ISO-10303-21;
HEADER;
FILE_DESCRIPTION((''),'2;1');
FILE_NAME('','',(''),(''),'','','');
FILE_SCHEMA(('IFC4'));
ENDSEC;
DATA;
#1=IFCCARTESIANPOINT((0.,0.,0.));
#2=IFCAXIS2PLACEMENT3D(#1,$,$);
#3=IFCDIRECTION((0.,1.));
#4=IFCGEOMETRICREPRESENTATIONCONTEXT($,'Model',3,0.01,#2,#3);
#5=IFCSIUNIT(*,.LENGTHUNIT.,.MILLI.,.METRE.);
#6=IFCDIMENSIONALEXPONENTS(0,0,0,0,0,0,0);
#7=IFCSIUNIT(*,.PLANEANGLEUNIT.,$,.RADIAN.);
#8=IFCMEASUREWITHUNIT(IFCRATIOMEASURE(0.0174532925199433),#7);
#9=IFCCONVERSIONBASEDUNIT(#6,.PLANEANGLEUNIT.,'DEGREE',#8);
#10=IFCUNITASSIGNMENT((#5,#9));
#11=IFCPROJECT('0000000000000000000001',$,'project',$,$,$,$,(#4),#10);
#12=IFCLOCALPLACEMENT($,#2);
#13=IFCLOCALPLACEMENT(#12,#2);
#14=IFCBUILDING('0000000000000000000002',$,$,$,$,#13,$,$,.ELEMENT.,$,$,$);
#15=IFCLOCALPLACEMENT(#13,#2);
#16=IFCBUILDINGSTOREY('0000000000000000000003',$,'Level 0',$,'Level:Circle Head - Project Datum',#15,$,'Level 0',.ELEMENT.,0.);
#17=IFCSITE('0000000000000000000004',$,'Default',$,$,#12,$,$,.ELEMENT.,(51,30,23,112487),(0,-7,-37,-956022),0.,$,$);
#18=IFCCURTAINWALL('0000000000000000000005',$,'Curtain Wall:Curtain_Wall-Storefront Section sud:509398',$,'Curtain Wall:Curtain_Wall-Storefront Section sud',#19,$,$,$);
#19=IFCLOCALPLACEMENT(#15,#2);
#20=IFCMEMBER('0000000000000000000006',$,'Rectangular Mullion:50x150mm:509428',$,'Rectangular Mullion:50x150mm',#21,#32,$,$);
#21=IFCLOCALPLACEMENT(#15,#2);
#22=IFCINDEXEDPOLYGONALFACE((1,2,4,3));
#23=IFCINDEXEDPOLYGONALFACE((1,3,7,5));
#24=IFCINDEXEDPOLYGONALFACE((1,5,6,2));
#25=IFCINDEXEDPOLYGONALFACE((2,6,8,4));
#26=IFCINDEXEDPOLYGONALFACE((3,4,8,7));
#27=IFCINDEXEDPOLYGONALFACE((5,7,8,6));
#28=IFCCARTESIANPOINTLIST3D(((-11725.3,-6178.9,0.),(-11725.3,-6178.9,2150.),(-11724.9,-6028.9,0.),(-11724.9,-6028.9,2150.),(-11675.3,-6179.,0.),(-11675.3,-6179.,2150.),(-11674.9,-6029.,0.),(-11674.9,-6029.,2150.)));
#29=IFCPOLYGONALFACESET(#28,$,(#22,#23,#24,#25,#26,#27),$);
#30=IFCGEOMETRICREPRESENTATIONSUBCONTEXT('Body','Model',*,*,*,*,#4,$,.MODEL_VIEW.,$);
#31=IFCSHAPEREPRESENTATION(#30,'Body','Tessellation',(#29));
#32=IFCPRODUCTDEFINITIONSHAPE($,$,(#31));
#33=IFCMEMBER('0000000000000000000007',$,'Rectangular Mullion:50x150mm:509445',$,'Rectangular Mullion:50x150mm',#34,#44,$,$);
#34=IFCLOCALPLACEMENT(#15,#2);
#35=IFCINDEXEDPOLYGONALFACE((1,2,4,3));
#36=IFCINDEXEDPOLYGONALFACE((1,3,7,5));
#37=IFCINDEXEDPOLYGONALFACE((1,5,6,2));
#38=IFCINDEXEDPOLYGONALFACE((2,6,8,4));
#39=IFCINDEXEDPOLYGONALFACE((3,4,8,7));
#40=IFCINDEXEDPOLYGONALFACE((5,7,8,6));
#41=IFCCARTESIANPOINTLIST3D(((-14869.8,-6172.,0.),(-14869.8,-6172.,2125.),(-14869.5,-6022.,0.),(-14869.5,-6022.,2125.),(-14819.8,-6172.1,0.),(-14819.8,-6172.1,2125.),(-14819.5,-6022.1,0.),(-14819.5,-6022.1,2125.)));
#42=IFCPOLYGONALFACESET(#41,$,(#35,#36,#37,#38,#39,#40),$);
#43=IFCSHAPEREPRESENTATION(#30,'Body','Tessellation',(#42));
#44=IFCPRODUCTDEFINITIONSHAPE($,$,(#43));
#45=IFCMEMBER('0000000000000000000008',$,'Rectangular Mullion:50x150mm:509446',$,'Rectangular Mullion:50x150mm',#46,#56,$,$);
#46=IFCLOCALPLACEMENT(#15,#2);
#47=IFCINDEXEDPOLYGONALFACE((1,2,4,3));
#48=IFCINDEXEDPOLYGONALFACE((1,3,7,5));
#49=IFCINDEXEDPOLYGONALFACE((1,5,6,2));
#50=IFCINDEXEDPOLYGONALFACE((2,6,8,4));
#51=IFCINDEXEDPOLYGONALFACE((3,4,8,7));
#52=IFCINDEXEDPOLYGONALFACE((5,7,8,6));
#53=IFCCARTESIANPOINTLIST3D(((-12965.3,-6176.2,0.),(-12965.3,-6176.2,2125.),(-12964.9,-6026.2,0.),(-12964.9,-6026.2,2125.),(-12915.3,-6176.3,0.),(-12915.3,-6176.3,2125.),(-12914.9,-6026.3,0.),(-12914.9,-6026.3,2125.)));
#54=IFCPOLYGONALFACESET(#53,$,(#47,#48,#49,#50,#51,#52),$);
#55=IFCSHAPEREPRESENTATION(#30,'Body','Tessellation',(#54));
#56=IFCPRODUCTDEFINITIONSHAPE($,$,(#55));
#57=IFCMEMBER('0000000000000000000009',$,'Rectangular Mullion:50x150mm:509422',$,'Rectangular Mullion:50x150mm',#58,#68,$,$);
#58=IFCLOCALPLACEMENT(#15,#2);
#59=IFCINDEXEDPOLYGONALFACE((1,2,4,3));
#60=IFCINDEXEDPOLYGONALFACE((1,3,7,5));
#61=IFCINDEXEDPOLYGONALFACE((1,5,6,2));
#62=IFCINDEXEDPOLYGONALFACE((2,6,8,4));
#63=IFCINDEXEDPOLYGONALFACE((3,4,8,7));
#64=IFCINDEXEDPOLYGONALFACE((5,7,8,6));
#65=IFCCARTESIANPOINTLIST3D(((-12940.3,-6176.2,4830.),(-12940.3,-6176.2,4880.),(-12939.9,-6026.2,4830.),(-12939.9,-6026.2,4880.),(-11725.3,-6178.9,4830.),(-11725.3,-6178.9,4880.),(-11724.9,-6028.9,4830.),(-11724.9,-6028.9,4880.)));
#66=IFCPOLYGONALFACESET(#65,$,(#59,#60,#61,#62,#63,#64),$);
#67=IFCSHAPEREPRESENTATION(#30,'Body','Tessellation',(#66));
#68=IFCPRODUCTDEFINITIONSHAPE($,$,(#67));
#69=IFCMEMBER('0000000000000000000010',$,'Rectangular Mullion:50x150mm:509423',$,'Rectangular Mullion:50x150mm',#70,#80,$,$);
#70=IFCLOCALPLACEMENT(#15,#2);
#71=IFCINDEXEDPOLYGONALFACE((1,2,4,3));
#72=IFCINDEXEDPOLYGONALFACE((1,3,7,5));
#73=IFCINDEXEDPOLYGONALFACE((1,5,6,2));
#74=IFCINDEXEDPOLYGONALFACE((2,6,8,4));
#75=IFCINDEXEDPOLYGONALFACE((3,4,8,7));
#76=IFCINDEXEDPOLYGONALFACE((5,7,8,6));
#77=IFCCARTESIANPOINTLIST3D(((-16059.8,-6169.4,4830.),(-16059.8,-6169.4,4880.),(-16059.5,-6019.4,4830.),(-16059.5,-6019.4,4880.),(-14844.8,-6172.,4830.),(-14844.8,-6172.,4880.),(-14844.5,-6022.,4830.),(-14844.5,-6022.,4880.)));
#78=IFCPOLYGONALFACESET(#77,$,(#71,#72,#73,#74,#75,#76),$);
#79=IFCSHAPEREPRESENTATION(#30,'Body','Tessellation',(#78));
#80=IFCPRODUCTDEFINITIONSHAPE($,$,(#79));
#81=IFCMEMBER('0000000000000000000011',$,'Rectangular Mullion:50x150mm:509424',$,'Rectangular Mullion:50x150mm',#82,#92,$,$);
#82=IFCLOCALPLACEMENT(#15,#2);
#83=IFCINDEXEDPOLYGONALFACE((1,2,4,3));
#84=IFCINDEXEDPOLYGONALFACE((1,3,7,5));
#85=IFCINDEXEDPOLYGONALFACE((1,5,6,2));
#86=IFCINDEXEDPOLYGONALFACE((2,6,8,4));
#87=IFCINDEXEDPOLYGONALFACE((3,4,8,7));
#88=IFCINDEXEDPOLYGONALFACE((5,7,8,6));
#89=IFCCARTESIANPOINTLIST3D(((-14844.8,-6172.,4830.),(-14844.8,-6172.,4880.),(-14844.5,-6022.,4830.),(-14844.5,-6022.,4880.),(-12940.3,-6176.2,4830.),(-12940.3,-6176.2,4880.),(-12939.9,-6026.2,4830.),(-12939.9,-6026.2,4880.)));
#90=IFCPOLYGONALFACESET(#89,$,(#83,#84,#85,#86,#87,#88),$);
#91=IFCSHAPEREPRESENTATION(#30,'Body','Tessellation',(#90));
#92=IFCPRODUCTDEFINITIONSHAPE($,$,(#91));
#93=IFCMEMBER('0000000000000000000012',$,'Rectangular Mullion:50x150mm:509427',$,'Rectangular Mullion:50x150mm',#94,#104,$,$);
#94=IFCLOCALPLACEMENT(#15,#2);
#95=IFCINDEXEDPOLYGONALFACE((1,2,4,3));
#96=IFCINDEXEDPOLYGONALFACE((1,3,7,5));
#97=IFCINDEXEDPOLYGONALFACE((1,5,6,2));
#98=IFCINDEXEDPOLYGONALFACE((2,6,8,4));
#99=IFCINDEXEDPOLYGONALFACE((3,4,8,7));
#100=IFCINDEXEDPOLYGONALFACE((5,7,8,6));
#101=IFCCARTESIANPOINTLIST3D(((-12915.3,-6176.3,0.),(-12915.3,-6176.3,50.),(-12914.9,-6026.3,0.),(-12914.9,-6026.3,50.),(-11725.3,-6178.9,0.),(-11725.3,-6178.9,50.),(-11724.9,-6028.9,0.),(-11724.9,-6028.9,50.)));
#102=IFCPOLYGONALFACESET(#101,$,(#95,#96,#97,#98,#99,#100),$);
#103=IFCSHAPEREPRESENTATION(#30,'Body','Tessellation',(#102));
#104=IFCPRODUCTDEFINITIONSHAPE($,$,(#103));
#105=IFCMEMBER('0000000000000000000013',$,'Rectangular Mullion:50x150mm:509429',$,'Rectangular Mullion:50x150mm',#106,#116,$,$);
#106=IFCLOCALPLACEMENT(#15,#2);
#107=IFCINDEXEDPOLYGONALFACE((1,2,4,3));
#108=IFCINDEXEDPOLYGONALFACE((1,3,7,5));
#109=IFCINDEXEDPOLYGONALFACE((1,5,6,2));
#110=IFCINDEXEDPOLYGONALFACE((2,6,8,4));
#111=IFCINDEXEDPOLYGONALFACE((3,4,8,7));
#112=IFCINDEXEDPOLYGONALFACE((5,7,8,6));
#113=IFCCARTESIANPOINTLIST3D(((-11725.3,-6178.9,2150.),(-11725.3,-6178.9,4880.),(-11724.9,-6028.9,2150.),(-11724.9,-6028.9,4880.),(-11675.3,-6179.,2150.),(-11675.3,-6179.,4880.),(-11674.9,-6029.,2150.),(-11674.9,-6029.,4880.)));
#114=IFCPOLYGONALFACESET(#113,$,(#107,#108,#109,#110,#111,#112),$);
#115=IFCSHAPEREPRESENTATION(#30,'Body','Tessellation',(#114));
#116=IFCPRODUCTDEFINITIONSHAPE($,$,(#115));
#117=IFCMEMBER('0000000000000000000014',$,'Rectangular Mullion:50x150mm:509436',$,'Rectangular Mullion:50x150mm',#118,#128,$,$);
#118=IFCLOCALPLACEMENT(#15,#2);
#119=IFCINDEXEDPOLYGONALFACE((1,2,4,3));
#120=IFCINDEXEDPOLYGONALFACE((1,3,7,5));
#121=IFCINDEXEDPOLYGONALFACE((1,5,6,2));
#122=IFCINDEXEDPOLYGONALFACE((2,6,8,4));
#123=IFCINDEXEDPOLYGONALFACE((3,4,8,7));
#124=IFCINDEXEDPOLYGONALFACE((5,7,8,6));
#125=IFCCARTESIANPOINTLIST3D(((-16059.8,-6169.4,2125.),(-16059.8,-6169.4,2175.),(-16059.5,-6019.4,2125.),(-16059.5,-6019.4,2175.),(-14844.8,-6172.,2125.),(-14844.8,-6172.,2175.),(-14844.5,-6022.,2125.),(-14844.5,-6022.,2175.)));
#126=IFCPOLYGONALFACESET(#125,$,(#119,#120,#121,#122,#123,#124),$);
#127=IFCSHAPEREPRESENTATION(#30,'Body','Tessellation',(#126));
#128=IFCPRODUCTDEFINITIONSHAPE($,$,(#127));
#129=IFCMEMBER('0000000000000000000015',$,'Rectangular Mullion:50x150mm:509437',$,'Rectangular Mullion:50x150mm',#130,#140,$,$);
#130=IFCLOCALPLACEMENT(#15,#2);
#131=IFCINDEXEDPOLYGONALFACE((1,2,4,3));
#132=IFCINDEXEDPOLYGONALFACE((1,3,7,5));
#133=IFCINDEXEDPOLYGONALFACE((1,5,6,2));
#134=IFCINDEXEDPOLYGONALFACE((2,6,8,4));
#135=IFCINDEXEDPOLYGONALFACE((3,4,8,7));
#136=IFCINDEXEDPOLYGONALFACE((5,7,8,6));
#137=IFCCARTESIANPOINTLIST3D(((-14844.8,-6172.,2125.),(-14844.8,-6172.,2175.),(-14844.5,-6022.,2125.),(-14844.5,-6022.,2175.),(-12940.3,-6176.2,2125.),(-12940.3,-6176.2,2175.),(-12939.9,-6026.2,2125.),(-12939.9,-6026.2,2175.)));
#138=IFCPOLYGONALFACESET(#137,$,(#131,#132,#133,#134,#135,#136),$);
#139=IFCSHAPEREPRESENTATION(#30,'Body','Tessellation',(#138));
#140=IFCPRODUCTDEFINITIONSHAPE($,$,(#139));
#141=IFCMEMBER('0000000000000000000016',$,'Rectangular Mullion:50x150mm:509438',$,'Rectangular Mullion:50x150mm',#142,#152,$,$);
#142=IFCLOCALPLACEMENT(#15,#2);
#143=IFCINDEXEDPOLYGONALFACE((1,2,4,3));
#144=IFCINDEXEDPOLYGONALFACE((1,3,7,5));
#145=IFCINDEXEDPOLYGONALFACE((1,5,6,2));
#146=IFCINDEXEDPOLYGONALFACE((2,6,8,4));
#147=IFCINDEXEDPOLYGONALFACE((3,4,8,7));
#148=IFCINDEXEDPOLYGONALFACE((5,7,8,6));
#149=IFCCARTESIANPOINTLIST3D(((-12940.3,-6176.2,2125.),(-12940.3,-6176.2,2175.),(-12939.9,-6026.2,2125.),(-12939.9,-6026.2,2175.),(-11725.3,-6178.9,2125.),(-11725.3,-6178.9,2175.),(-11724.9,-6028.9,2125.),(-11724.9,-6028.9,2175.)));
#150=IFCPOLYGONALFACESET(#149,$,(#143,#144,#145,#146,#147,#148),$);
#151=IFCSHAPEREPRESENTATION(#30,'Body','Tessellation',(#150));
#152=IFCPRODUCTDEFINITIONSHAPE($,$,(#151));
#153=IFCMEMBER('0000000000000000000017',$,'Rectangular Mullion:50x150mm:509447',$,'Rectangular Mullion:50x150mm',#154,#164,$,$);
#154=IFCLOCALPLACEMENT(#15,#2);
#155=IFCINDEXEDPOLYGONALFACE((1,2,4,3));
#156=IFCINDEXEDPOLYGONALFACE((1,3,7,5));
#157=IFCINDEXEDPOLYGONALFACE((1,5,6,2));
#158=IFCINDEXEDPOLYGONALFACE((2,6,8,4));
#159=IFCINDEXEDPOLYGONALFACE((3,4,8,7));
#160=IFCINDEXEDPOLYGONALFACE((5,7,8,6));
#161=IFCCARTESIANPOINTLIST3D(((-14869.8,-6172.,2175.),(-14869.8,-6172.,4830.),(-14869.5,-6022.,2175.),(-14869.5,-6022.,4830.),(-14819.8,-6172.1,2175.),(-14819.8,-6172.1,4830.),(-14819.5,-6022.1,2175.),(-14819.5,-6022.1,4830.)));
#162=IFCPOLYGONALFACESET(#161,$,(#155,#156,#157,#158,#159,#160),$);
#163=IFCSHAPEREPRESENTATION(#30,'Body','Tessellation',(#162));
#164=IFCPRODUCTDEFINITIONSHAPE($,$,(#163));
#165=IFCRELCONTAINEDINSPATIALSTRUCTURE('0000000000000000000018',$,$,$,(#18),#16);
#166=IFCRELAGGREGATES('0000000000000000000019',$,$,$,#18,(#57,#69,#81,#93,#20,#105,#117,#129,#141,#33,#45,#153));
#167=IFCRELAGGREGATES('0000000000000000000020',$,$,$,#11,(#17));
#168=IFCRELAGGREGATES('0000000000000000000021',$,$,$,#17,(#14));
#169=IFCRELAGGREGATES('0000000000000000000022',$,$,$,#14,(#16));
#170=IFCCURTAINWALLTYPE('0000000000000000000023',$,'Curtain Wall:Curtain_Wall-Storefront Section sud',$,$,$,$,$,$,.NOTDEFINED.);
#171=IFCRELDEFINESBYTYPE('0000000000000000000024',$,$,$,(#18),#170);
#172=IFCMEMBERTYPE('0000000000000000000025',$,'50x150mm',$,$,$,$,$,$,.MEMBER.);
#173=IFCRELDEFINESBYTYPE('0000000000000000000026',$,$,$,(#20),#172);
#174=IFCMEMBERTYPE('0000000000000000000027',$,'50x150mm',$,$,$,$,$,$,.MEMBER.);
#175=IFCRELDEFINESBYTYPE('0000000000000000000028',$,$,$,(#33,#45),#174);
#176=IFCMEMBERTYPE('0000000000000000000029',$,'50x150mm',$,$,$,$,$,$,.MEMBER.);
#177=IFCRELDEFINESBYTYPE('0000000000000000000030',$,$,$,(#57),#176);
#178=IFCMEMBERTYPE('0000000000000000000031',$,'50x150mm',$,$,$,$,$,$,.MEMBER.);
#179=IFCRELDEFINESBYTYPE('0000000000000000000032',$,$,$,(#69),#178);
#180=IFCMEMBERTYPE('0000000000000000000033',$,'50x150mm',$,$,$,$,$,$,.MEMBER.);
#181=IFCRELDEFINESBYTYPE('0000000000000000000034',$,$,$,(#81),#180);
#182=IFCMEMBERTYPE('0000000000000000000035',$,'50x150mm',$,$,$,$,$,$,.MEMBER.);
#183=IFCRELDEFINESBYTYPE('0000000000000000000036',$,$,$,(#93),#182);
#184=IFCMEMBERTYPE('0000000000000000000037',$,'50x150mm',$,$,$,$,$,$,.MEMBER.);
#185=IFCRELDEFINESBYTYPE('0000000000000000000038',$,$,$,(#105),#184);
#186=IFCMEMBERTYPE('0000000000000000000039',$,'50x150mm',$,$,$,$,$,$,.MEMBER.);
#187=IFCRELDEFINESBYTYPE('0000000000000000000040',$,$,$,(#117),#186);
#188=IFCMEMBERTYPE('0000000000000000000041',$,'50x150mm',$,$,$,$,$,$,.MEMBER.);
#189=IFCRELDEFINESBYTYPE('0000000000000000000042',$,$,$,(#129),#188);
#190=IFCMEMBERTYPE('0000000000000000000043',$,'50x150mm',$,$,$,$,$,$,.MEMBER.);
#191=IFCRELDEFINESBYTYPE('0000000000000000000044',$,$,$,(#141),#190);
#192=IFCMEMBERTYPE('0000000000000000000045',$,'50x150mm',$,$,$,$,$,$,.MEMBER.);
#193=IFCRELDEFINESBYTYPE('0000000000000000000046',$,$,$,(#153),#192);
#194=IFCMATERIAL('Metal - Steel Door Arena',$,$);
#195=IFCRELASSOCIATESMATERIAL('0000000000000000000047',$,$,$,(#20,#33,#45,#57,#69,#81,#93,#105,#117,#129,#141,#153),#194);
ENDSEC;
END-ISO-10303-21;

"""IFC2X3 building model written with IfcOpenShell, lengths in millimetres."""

from ifc_helpers import new_model, entity, si_unit, converted_unit, direction, frame, origin, origin_2d_with_axis, place, context, subcontext, project, spatial, rectangle, extrude, source, transform, mapped, material, type_object, type_shapes, element, aggregate, save


model = new_model("IFC2X3")

# Units and contexts
model_context = context("Model", 3, precision=0.01, world=origin(), true_north=direction((0.0, 1.0)))
body_context = subcontext(model_context, "Body", "Model", "MODEL_VIEW")
ifc_project = project(units=[si_unit("LENGTHUNIT", "METRE", prefix="MILLI"), converted_unit("PLANEANGLEUNIT", "DEGREE", entity("IfcRatioMeasure", 0.0174532925199433), si_unit("PLANEANGLEUNIT", "RADIAN"), dimensions=[0, 0, 0, 0, 0, 0, 0])], contexts=[model_context])

# Site, building, storey
site_placement = place(None, origin())
site = spatial("IfcSite", under=ifc_project, at=site_placement, Name="Default", CompositionType="ELEMENT", RefLatitude=(51, 30, 23, 112487), RefLongitude=(0, -7, -37, -956022), RefElevation=0.0)
building_placement = place(site_placement, origin())
building = spatial("IfcBuilding", under=site, at=building_placement, CompositionType="ELEMENT")
storey_placement = place(building_placement, origin())
storey = spatial("IfcBuildingStorey", under=building, at=storey_placement, Name="Level 0", ObjectType="Level:Circle Head - Project Datum", LongName="Level 0", CompositionType="ELEMENT", Elevation=0.0)

# Curtain wall, members
curtain_wall_type = type_object("IfcCurtainWallType", Name="Curtain Wall:Curtain_Wall-Storefront Section sud", PredefinedType="NOTDEFINED")
curtain_wall_placement = place(storey_placement, origin())
curtain_wall = element("IfcCurtainWall", 1, at=curtain_wall_placement, inside=storey, type_object=curtain_wall_type, Name="Curtain Wall:Curtain_Wall-Storefront Section sud:509398", ObjectType="Curtain Wall:Curtain_Wall-Storefront Section sud")
ifc_material_1 = material(Name="Metal - Steel Door Arena")
member_type_1 = type_object("IfcMemberType", Name="50x150mm", PredefinedType="MEMBER")
shared_shape_1 = source(origin(), body_context, "Body", "SweptSolid", [
    extrude(rectangle(XDim=150.0, YDim=50.0, at=origin_2d_with_axis()), frame((-25.0, 0.0, -2150.0), z_axis=(0.0, 0.0, 1.0), x_axis=(0.0, -1.0, 0.0)), (0.0, 0.0, 1.0), 2150.0),
])
type_shapes(member_type_1, [shared_shape_1])
member_1_placement = place(storey_placement, frame((-11675.1, -6104.0, 0.0), z_axis=(0.0, 0.0, -1.0), x_axis=(0.999998, -0.002199, 0.0)))
member_1 = element("IfcMember", 2, at=member_1_placement, type_object=member_type_1, material=ifc_material_1, Name="Rectangular Mullion:50x150mm:509428", ObjectType="Rectangular Mullion:50x150mm", context=body_context, shape_type="MappedRepresentation", body=[
    mapped(shared_shape_1, transform((0.0, 0.0, 0.0), scale=1.0)),
])
member_type_2 = type_object("IfcMemberType", Name="50x150mm", PredefinedType="MEMBER")
shared_shape_2 = source(origin(), body_context, "Body", "SweptSolid", [
    extrude(rectangle(XDim=150.0, YDim=50.0, at=origin_2d_with_axis()), frame((0.0, 0.0, -2125.0), z_axis=(0.0, 0.0, 1.0), x_axis=(0.0, -1.0, 0.0)), (0.0, 0.0, 1.0), 2125.0),
])
type_shapes(member_type_2, [shared_shape_2])
member_2_placement = place(storey_placement, frame((-14844.6, -6097.0, 0.0), z_axis=(0.0, 0.0, -1.0), x_axis=(0.999998, -0.002199, 0.0)))
member_2 = element("IfcMember", 3, at=member_2_placement, type_object=member_type_2, material=ifc_material_1, Name="Rectangular Mullion:50x150mm:509445", ObjectType="Rectangular Mullion:50x150mm", context=body_context, shape_type="MappedRepresentation", body=[
    mapped(shared_shape_2, transform((0.0, 0.0, 0.0), scale=1.0)),
])
member_3_placement = place(storey_placement, frame((-12940.1, -6101.2, 0.0), z_axis=(0.0, 0.0, -1.0), x_axis=(0.999998, -0.002199, 0.0)))
member_3 = element("IfcMember", 4, at=member_3_placement, type_object=member_type_2, material=ifc_material_1, Name="Rectangular Mullion:50x150mm:509446", ObjectType="Rectangular Mullion:50x150mm", context=body_context, shape_type="MappedRepresentation", body=[
    mapped(shared_shape_2, transform((0.0, 0.0, 0.0), scale=1.0)),
])
member_type_3 = type_object("IfcMemberType", Name="50x150mm", PredefinedType="MEMBER")
shared_shape_3 = source(origin(), body_context, "Body", "SweptSolid", [
    extrude(rectangle(XDim=150.0, YDim=50.0, at=origin_2d_with_axis()), frame((-25.0, 0.0, -1215.0), z_axis=(0.0, 0.0, 1.0), x_axis=(0.0, -1.0, 0.0)), (0.0, 0.0, 1.0), 1215.0),
])
type_shapes(member_type_3, [shared_shape_3])
member_4_placement = place(storey_placement, frame((-11725.1, -6103.9, 4880.0), z_axis=(0.999998, -0.002199, 0.0), x_axis=(0.0, 0.0, 1.0)))
member_4 = element("IfcMember", 5, at=member_4_placement, type_object=member_type_3, material=ifc_material_1, Name="Rectangular Mullion:50x150mm:509422", ObjectType="Rectangular Mullion:50x150mm", context=body_context, shape_type="MappedRepresentation", body=[
    mapped(shared_shape_3, transform((0.0, 0.0, 0.0), scale=1.0)),
])
member_type_4 = type_object("IfcMemberType", Name="50x150mm", PredefinedType="MEMBER")
shared_shape_4 = source(origin(), body_context, "Body", "SweptSolid", [
    extrude(rectangle(XDim=150.0, YDim=50.0, at=origin_2d_with_axis()), frame((-25.0, 0.0, -1215.0), z_axis=(0.0, 0.0, 1.0), x_axis=(0.0, -1.0, 0.0)), (0.0, 0.0, 1.0), 1215.0),
])
type_shapes(member_type_4, [shared_shape_4])
member_5_placement = place(storey_placement, frame((-14844.6, -6097.0, 4880.0), z_axis=(0.999998, -0.002199, 0.0), x_axis=(0.0, 0.0, 1.0)))
member_5 = element("IfcMember", 6, at=member_5_placement, type_object=member_type_4, material=ifc_material_1, Name="Rectangular Mullion:50x150mm:509423", ObjectType="Rectangular Mullion:50x150mm", context=body_context, shape_type="MappedRepresentation", body=[
    mapped(shared_shape_4, transform((0.0, 0.0, 0.0), scale=1.0)),
])
member_type_5 = type_object("IfcMemberType", Name="50x150mm", PredefinedType="MEMBER")
shared_shape_5 = source(origin(), body_context, "Body", "SweptSolid", [
    extrude(rectangle(XDim=150.0, YDim=50.0, at=origin_2d_with_axis()), frame((-25.0, 0.0, -1904.5), z_axis=(0.0, 0.0, 1.0), x_axis=(0.0, -1.0, 0.0)), (0.0, 0.0, 1.0), 1904.5),
])
type_shapes(member_type_5, [shared_shape_5])
member_6_placement = place(storey_placement, frame((-12940.1, -6101.2, 4880.0), z_axis=(0.999998, -0.002199, 0.0), x_axis=(0.0, 0.0, 1.0)))
member_6 = element("IfcMember", 7, at=member_6_placement, type_object=member_type_5, material=ifc_material_1, Name="Rectangular Mullion:50x150mm:509424", ObjectType="Rectangular Mullion:50x150mm", context=body_context, shape_type="MappedRepresentation", body=[
    mapped(shared_shape_5, transform((0.0, 0.0, 0.0), scale=1.0)),
])
member_type_6 = type_object("IfcMemberType", Name="50x150mm", PredefinedType="MEMBER")
shared_shape_6 = source(origin(), body_context, "Body", "SweptSolid", [
    extrude(rectangle(XDim=150.0, YDim=50.0, at=origin_2d_with_axis()), frame((-25.0, 0.0, -1190.0), z_axis=(0.0, 0.0, 1.0), x_axis=(0.0, -1.0, 0.0)), (0.0, 0.0, 1.0), 1190.0),
])
type_shapes(member_type_6, [shared_shape_6])
member_7_placement = place(storey_placement, frame((-12915.1, -6101.3, 0.0), z_axis=(-0.999998, 0.002199, 0.0), x_axis=(0.0, 0.0, -1.0)))
member_7 = element("IfcMember", 8, at=member_7_placement, type_object=member_type_6, material=ifc_material_1, Name="Rectangular Mullion:50x150mm:509427", ObjectType="Rectangular Mullion:50x150mm", context=body_context, shape_type="MappedRepresentation", body=[
    mapped(shared_shape_6, transform((0.0, 0.0, 0.0), scale=1.0)),
])
member_type_7 = type_object("IfcMemberType", Name="50x150mm", PredefinedType="MEMBER")
shared_shape_7 = source(origin(), body_context, "Body", "SweptSolid", [
    extrude(rectangle(XDim=150.0, YDim=50.0, at=origin_2d_with_axis()), frame((-25.0, 0.0, -2730.0), z_axis=(0.0, 0.0, 1.0), x_axis=(0.0, -1.0, 0.0)), (0.0, 0.0, 1.0), 2730.0),
])
type_shapes(member_type_7, [shared_shape_7])
member_8_placement = place(storey_placement, frame((-11675.1, -6104.0, 2150.0), z_axis=(0.0, 0.0, -1.0), x_axis=(0.999998, -0.002199, 0.0)))
member_8 = element("IfcMember", 9, at=member_8_placement, type_object=member_type_7, material=ifc_material_1, Name="Rectangular Mullion:50x150mm:509429", ObjectType="Rectangular Mullion:50x150mm", context=body_context, shape_type="MappedRepresentation", body=[
    mapped(shared_shape_7, transform((0.0, 0.0, 0.0), scale=1.0)),
])
member_type_8 = type_object("IfcMemberType", Name="50x150mm", PredefinedType="MEMBER")
shared_shape_8 = source(origin(), body_context, "Body", "SweptSolid", [
    extrude(rectangle(XDim=150.0, YDim=50.0, at=origin_2d_with_axis()), frame((0.0, 0.0, -1215.0), z_axis=(0.0, 0.0, 1.0), x_axis=(0.0, -1.0, 0.0)), (0.0, 0.0, 1.0), 1215.0),
])
type_shapes(member_type_8, [shared_shape_8])
member_9_placement = place(storey_placement, frame((-14844.6, -6097.0, 2150.0), z_axis=(0.999998, -0.002199, 0.0), x_axis=(0.0, 0.0, 1.0)))
member_9 = element("IfcMember", 10, at=member_9_placement, type_object=member_type_8, material=ifc_material_1, Name="Rectangular Mullion:50x150mm:509436", ObjectType="Rectangular Mullion:50x150mm", context=body_context, shape_type="MappedRepresentation", body=[
    mapped(shared_shape_8, transform((0.0, 0.0, 0.0), scale=1.0)),
])
member_type_9 = type_object("IfcMemberType", Name="50x150mm", PredefinedType="MEMBER")
shared_shape_9 = source(origin(), body_context, "Body", "SweptSolid", [
    extrude(rectangle(XDim=150.0, YDim=50.0, at=origin_2d_with_axis()), frame((0.0, 0.0, -1904.5), z_axis=(0.0, 0.0, 1.0), x_axis=(0.0, -1.0, 0.0)), (0.0, 0.0, 1.0), 1904.5),
])
type_shapes(member_type_9, [shared_shape_9])
member_10_placement = place(storey_placement, frame((-12940.1, -6101.2, 2150.0), z_axis=(0.999998, -0.002199, 0.0), x_axis=(0.0, 0.0, 1.0)))
member_10 = element("IfcMember", 11, at=member_10_placement, type_object=member_type_9, material=ifc_material_1, Name="Rectangular Mullion:50x150mm:509437", ObjectType="Rectangular Mullion:50x150mm", context=body_context, shape_type="MappedRepresentation", body=[
    mapped(shared_shape_9, transform((0.0, 0.0, 0.0), scale=1.0)),
])
member_type_10 = type_object("IfcMemberType", Name="50x150mm", PredefinedType="MEMBER")
shared_shape_10 = source(origin(), body_context, "Body", "SweptSolid", [
    extrude(rectangle(XDim=150.0, YDim=50.0, at=origin_2d_with_axis()), frame((0.0, 0.0, -1215.0), z_axis=(0.0, 0.0, 1.0), x_axis=(0.0, -1.0, 0.0)), (0.0, 0.0, 1.0), 1215.0),
])
type_shapes(member_type_10, [shared_shape_10])
member_11_placement = place(storey_placement, frame((-11725.1, -6103.9, 2150.0), z_axis=(0.999998, -0.002199, 0.0), x_axis=(0.0, 0.0, 1.0)))
member_11 = element("IfcMember", 12, at=member_11_placement, type_object=member_type_10, material=ifc_material_1, Name="Rectangular Mullion:50x150mm:509438", ObjectType="Rectangular Mullion:50x150mm", context=body_context, shape_type="MappedRepresentation", body=[
    mapped(shared_shape_10, transform((0.0, 0.0, 0.0), scale=1.0)),
])
member_type_11 = type_object("IfcMemberType", Name="50x150mm", PredefinedType="MEMBER")
shared_shape_11 = source(origin(), body_context, "Body", "SweptSolid", [
    extrude(rectangle(XDim=150.0, YDim=50.0, at=origin_2d_with_axis()), frame((0.0, 0.0, -2655.0), z_axis=(0.0, 0.0, 1.0), x_axis=(0.0, -1.0, 0.0)), (0.0, 0.0, 1.0), 2655.0),
])
type_shapes(member_type_11, [shared_shape_11])
member_12_placement = place(storey_placement, frame((-14844.6, -6097.0, 2175.0), z_axis=(0.0, 0.0, -1.0), x_axis=(0.999998, -0.002199, 0.0)))
member_12 = element("IfcMember", 13, at=member_12_placement, type_object=member_type_11, material=ifc_material_1, Name="Rectangular Mullion:50x150mm:509447", ObjectType="Rectangular Mullion:50x150mm", context=body_context, shape_type="MappedRepresentation", body=[
    mapped(shared_shape_11, transform((0.0, 0.0, 0.0), scale=1.0)),
])
aggregate(curtain_wall, [member_4, member_5, member_6, member_7, member_1, member_8, member_9, member_10, member_11, member_2, member_3, member_12])

save(model, "model.ifc")
